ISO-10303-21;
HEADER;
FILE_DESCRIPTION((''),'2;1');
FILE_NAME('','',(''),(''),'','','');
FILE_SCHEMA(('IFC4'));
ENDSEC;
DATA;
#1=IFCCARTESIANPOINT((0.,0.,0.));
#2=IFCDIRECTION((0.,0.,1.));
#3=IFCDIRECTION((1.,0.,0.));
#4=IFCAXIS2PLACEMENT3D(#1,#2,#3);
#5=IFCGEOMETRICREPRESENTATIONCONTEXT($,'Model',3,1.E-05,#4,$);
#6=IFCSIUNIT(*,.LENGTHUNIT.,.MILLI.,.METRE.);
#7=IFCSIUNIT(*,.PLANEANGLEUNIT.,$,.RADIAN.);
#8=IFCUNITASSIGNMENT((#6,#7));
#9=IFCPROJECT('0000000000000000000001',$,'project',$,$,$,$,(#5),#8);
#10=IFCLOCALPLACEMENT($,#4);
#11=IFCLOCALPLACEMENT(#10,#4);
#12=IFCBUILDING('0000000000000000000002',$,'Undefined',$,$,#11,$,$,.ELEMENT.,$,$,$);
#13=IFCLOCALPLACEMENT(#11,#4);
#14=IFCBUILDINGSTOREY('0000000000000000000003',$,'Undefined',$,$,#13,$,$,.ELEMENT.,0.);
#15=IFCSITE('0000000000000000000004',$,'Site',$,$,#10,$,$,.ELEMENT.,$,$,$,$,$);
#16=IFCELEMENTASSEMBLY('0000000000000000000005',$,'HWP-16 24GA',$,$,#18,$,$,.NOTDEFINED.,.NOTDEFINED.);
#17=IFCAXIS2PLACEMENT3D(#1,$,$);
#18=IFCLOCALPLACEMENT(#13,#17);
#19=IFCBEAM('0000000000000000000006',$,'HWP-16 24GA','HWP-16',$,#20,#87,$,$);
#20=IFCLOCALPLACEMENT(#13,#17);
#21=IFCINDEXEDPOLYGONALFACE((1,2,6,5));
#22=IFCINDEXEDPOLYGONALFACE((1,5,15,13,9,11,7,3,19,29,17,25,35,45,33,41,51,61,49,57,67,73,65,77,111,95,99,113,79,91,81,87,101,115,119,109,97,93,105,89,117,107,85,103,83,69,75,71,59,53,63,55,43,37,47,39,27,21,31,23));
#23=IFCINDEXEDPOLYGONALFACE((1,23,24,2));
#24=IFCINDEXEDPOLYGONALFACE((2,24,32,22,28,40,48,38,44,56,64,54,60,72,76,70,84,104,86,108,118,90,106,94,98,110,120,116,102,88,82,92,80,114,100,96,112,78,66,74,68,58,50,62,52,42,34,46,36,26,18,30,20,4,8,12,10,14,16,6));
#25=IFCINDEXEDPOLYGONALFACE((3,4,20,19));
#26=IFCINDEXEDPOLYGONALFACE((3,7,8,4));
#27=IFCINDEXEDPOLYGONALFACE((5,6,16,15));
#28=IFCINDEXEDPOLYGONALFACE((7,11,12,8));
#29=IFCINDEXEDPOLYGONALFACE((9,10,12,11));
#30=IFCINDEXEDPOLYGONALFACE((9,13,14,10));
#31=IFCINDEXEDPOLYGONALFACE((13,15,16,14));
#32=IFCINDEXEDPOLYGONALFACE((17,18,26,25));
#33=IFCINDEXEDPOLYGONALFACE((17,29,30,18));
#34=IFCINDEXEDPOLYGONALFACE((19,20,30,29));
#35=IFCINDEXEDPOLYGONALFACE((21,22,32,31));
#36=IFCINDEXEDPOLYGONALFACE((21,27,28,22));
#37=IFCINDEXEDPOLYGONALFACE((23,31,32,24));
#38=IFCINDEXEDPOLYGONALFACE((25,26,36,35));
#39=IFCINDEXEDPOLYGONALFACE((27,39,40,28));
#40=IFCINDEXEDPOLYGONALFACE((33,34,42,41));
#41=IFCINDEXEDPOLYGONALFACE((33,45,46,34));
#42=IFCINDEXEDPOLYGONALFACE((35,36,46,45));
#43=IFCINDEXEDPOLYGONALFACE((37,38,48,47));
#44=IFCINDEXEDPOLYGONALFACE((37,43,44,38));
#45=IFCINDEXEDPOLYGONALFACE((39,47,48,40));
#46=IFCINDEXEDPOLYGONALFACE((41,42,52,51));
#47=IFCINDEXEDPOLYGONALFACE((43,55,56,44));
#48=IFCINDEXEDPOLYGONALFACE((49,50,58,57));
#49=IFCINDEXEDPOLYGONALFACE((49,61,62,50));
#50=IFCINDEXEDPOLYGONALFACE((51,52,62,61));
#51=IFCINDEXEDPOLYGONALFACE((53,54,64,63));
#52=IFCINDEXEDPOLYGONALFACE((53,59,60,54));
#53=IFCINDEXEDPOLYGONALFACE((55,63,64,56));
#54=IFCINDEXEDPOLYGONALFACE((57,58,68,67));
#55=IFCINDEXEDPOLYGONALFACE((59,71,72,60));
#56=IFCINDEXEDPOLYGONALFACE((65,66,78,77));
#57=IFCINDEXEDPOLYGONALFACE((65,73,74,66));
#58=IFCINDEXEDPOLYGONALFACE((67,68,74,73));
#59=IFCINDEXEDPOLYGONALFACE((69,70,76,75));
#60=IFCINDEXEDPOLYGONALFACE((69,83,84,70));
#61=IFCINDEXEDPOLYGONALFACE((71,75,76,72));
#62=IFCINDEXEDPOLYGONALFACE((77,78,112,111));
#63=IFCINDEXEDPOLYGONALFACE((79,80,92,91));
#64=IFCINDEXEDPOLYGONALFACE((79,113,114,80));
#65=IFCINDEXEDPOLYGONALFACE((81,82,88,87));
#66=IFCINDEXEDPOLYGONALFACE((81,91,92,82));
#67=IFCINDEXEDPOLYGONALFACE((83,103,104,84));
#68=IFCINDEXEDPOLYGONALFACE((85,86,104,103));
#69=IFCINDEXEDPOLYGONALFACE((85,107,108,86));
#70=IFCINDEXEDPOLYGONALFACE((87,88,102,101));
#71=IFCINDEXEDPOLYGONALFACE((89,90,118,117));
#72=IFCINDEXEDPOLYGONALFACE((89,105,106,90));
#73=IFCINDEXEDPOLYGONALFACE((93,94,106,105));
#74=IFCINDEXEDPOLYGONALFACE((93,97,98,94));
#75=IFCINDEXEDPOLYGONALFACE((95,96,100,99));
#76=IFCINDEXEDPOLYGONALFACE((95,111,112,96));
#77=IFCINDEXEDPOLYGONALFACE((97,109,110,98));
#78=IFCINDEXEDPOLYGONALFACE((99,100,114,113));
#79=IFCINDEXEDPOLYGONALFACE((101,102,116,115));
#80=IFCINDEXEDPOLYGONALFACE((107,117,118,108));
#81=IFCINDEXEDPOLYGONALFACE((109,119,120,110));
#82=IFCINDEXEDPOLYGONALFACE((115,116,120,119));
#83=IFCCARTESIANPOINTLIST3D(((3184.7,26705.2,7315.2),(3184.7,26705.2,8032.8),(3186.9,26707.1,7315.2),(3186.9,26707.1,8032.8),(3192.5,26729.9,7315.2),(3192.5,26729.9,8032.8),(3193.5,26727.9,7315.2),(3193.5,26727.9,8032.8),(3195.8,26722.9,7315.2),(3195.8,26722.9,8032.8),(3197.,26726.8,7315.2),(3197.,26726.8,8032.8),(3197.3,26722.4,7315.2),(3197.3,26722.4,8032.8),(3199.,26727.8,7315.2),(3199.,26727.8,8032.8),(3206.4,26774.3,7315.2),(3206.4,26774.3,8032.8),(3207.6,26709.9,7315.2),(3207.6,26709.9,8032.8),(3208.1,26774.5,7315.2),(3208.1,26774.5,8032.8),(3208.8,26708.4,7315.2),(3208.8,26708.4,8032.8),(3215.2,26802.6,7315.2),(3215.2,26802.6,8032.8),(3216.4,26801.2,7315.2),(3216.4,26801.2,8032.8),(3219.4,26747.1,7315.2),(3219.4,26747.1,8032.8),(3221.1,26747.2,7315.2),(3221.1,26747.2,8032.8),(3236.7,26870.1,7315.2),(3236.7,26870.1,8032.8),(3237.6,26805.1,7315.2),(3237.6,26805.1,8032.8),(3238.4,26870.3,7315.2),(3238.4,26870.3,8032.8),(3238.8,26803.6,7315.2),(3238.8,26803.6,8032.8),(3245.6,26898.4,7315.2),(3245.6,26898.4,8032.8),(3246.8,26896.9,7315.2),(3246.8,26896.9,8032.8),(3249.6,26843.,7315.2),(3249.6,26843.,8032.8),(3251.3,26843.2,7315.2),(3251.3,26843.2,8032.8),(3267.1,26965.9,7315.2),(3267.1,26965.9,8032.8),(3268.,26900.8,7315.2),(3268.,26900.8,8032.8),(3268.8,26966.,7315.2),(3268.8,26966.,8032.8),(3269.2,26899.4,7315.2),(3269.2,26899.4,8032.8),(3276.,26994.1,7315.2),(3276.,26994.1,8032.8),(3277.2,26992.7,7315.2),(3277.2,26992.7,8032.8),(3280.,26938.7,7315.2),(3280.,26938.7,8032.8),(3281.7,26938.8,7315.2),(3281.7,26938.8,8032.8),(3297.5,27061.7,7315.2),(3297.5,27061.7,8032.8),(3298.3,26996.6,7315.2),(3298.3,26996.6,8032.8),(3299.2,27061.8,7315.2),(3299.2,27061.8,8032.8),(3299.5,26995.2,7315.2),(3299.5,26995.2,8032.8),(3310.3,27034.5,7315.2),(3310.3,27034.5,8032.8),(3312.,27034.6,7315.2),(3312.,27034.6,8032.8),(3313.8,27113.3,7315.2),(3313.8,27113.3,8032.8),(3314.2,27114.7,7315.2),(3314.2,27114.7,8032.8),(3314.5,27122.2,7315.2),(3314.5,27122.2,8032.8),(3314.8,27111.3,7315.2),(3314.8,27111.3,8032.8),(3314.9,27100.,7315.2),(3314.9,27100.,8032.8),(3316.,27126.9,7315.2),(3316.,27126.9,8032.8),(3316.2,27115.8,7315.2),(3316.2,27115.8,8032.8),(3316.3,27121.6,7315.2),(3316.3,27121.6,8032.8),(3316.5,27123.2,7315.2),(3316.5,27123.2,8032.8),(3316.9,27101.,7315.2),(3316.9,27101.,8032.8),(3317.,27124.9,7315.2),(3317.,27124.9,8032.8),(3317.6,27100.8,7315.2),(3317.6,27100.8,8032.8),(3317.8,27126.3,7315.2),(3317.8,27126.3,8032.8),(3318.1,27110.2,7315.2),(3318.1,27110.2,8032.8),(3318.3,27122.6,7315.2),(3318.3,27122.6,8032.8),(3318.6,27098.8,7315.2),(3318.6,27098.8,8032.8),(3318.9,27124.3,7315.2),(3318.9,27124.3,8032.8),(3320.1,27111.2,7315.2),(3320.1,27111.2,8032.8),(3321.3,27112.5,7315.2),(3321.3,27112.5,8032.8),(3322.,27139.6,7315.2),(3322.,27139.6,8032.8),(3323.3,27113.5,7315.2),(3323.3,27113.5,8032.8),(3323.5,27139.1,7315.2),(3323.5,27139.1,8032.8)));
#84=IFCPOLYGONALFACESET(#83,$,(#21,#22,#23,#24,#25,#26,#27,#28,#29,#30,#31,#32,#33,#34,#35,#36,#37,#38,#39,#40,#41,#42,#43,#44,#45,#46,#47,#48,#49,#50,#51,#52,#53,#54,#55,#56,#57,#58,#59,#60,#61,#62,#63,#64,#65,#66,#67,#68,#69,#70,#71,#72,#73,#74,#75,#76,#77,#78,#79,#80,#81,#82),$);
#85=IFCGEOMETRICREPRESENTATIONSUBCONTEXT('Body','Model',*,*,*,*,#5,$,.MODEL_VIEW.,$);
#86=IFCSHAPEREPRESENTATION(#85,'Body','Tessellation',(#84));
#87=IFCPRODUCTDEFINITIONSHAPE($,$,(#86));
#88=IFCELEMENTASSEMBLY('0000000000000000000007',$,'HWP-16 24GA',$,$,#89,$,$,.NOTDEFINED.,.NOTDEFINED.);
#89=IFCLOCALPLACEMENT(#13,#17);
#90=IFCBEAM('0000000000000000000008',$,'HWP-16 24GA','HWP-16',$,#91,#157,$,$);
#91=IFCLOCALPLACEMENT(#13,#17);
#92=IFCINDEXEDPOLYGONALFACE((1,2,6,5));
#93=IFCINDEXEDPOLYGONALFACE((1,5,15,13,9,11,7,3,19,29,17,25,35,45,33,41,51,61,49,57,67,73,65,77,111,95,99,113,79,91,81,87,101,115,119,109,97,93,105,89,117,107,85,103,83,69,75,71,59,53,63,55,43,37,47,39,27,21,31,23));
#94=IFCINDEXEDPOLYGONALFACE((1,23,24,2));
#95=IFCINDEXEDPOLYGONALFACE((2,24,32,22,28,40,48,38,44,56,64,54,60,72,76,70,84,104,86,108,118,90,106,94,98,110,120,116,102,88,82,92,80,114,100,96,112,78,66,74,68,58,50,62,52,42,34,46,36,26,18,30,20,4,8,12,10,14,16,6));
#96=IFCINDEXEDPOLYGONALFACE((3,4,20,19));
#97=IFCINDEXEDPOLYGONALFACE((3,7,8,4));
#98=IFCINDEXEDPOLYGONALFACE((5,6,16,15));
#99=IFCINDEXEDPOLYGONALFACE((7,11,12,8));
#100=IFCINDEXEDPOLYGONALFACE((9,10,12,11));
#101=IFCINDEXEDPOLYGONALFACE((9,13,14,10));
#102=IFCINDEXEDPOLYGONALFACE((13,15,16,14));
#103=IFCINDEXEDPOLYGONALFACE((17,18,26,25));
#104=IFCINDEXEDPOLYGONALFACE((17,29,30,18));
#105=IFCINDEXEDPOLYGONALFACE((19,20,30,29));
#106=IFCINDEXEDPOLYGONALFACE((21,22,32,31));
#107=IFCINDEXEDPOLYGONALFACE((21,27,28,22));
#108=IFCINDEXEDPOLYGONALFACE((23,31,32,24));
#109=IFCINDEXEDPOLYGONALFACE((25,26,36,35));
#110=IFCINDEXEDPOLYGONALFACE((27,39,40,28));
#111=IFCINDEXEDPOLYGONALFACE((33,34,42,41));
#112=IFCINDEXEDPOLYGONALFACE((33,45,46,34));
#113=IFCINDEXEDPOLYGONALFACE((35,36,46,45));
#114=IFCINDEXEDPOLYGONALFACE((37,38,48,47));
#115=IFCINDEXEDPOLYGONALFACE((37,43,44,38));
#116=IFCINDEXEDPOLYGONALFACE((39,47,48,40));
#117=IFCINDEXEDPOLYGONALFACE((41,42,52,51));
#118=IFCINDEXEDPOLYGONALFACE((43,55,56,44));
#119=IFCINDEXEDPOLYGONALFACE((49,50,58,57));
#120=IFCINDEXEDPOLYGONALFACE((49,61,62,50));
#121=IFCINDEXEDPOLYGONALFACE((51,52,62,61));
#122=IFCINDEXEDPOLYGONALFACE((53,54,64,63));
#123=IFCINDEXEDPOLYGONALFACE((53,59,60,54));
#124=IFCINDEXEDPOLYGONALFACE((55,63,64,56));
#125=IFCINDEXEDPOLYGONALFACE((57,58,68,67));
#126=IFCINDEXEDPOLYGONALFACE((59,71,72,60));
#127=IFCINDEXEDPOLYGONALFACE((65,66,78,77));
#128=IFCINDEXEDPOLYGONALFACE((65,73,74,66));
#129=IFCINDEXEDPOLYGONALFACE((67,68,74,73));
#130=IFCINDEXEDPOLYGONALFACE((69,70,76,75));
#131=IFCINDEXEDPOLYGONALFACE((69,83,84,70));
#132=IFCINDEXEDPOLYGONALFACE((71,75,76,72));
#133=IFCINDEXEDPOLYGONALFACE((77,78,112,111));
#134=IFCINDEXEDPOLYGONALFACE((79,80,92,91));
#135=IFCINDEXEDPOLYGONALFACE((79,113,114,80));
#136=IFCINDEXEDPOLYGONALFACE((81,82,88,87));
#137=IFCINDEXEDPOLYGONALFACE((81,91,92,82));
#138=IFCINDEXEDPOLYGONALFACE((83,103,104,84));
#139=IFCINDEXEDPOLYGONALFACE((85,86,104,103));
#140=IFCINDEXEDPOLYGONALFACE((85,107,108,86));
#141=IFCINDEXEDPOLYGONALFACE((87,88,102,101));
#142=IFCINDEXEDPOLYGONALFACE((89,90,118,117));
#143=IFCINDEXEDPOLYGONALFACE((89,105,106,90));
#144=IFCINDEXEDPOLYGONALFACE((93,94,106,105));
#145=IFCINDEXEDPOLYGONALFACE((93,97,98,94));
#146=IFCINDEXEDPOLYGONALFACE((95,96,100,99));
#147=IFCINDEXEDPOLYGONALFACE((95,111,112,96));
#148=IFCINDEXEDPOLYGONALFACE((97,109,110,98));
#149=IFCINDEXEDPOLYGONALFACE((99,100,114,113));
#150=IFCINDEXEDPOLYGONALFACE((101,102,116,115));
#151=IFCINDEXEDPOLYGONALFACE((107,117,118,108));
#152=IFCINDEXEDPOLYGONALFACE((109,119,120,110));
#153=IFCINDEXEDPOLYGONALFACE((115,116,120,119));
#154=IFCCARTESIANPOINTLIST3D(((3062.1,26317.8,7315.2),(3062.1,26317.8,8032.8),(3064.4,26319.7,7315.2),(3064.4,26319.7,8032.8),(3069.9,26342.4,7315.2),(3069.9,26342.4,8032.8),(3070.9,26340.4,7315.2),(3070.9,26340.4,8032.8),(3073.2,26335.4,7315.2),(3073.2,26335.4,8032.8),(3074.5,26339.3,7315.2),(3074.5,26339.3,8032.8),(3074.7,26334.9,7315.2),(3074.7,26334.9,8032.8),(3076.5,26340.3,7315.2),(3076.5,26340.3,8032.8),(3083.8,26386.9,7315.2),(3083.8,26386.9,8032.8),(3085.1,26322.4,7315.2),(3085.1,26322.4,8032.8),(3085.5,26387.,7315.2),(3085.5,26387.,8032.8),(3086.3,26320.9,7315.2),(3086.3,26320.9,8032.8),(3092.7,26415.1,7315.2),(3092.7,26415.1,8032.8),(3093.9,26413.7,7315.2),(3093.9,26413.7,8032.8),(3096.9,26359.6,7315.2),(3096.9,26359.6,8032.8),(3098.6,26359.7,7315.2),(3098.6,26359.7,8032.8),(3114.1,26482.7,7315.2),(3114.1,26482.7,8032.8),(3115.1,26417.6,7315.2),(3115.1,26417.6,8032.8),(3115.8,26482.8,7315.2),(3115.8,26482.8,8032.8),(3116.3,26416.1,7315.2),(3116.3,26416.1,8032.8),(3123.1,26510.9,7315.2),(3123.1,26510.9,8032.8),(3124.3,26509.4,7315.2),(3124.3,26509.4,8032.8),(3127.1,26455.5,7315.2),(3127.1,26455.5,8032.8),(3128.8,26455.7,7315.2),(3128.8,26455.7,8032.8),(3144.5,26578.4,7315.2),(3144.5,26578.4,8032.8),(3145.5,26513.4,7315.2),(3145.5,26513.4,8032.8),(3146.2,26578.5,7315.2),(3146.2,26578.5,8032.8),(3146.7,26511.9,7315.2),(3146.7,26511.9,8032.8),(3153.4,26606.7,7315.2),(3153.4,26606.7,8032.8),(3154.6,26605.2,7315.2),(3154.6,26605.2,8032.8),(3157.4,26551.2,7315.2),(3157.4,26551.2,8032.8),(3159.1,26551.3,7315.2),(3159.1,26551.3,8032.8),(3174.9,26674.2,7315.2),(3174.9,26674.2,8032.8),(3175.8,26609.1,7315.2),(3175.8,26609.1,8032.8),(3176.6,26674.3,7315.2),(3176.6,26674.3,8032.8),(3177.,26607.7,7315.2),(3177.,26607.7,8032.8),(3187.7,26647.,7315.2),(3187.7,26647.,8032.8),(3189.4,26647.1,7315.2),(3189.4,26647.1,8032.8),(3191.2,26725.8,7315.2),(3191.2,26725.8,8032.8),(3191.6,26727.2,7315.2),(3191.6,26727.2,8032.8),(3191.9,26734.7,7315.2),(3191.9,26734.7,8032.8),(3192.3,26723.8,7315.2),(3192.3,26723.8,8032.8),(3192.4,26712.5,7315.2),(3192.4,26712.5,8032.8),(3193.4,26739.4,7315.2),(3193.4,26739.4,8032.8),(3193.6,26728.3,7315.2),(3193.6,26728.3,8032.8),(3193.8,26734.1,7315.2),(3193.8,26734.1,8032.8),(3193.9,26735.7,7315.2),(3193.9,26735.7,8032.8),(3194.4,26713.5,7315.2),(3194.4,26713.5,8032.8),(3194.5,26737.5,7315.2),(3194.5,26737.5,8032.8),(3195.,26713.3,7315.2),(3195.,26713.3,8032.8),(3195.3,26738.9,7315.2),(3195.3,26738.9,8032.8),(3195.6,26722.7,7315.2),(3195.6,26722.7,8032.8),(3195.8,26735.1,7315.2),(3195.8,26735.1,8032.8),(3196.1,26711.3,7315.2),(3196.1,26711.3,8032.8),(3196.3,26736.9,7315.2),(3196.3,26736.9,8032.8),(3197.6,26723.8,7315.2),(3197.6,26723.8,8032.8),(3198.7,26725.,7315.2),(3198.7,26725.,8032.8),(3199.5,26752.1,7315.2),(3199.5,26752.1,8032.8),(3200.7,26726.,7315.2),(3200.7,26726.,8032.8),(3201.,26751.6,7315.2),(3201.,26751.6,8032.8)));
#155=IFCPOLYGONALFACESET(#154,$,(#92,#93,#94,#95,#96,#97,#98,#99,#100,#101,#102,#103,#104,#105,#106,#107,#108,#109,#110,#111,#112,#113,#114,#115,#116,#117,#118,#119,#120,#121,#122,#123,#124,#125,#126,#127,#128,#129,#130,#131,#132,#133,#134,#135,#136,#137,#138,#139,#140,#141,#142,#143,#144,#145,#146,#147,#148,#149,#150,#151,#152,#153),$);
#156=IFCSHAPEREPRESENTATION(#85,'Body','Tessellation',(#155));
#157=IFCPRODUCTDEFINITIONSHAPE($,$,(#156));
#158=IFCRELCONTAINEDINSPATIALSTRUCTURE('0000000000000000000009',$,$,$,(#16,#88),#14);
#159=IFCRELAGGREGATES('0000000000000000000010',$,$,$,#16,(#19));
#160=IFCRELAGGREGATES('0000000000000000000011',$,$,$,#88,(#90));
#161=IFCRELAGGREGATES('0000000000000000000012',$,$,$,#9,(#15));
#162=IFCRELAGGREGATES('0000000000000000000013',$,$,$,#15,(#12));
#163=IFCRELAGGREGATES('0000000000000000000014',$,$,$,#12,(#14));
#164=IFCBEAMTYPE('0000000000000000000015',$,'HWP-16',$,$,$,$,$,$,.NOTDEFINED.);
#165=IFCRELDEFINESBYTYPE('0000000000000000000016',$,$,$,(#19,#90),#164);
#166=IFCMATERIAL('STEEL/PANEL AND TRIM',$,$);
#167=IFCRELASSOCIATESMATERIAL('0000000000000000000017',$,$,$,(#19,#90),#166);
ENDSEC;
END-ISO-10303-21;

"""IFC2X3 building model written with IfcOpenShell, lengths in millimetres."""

from ifc_helpers import new_model, si_unit, frame, origin_with_axes, place, context, subcontext, project, spatial, polyline, outline, extrude, clip, halfspace, material, type_object, element, aggregate, save


model = new_model("IFC2X3")

# Units and contexts
model_context = context("Model", 3, precision=1e-05, world=origin_with_axes())
body_context = subcontext(model_context, "Body", "Model", "MODEL_VIEW")
ifc_project = project(units=[si_unit("LENGTHUNIT", "METRE", prefix="MILLI"), si_unit("PLANEANGLEUNIT", "RADIAN")], contexts=[model_context])

# Site, building, storey
site_placement = place(None, origin_with_axes())
site = spatial("IfcSite", under=ifc_project, at=site_placement, Name="Site", CompositionType="ELEMENT")
building_placement = place(site_placement, origin_with_axes())
building = spatial("IfcBuilding", under=site, at=building_placement, Name="Undefined", CompositionType="ELEMENT")
storey_placement = place(building_placement, origin_with_axes())
storey = spatial("IfcBuildingStorey", under=building, at=storey_placement, Name="Undefined", CompositionType="ELEMENT", Elevation=0.0)

# Element assemblies, beams
ifc_material_1 = material(Name="STEEL/PANEL AND TRIM")
beam_type_1 = type_object("IfcBeamType", Name="HWP-16", PredefinedType="NOTDEFINED")
assembly_1_placement = place(storey_placement, origin_with_axes())
assembly_1 = element("IfcElementAssembly", 1, at=assembly_1_placement, inside=storey, Name="HWP-16 24GA", AssemblyPlace="NOTDEFINED", PredefinedType="NOTDEFINED")
beam_1_placement = place(assembly_1_placement, frame((3208.8, 26708.4, 8032.8), z_axis=(-0.953453, 0.301541, 0.0), x_axis=(0.0, 0.0, -1.0)))
beam_1 = element("IfcBeam", 2, at=beam_1_placement, type_object=beam_type_1, material=ifc_material_1, Name="HWP-16 24GA", Description="HWP-16", context=body_context, shape_type="Clipping", body=[
    clip(extrude(outline(polyline([(40.7, 0.0), (0.0, 0.0), (-10.3, 22.1), (15.5, 22.1), (15.5, 15.2), (9.9, 15.2), (9.9, 16.8), (13.9, 16.8), (13.9, 20.5), (-7.8, 20.5), (1.0, 1.6), (40.1, 1.6), (62.1, 22.2), (91.7, 22.3), (100.8, 1.7), (140.6, 1.7), (162.6, 22.2), (192.2, 22.2), (201.3, 1.6), (241.0, 1.6), (263.1, 22.1), (292.7, 22.1), (301.8, 1.6), (341.5, 1.6), (363.5, 22.0), (417.6, 22.0), (417.6, 15.3), (406.9, 15.3), (406.9, 14.6), (419.2, 14.6), (419.2, 22.1), (426.4, 22.1), (426.4, 24.0), (431.3, 24.0), (431.3, 22.1), (445.2, 22.1), (445.2, 20.5), (429.7, 20.5), (429.7, 22.5), (427.9, 22.5), (427.9, 20.5), (420.7, 20.5), (420.7, 13.0), (405.3, 13.0), (405.3, 16.9), (416.0, 16.9), (416.0, 20.4), (364.1, 20.4), (342.1, 0.0), (300.7, 0.0), (291.6, 20.5), (263.7, 20.5), (241.6, 0.0), (200.3, 0.0), (191.2, 20.6), (163.2, 20.6), (141.3, 0.1), (99.8, 0.1), (90.7, 20.7), (62.7, 20.6), (40.7, 0.0)])), frame((10000.0, 0.0, 0.0), z_axis=(-1.0, 0.0, 0.0), x_axis=(0.0, -1.0, 0.0)), (0.0, 0.0, 1.0), 10000.0), halfspace(frame((717.5, -500.0, -500.0), z_axis=(1.0, 0.0, 0.0), x_axis=(0.0, 0.0, 1.0)), False)),
])
aggregate(assembly_1, [beam_1])
assembly_2_placement = place(storey_placement, origin_with_axes())
assembly_2 = element("IfcElementAssembly", 3, at=assembly_2_placement, inside=storey, Name="HWP-16 24GA", AssemblyPlace="NOTDEFINED", PredefinedType="NOTDEFINED")
beam_2_placement = place(assembly_2_placement, frame((3086.3, 26320.9, 8032.8), z_axis=(-0.953453, 0.301541, 0.0), x_axis=(0.0, 0.0, -1.0)))
beam_2 = element("IfcBeam", 4, at=beam_2_placement, type_object=beam_type_1, material=ifc_material_1, Name="HWP-16 24GA", Description="HWP-16", context=body_context, shape_type="Clipping", body=[
    clip(extrude(outline(polyline([(40.7, 0.0), (0.0, 0.0), (-10.3, 22.1), (15.5, 22.1), (15.5, 15.2), (9.9, 15.2), (9.9, 16.8), (13.9, 16.8), (13.9, 20.5), (-7.8, 20.5), (1.0, 1.6), (40.1, 1.6), (62.1, 22.2), (91.7, 22.3), (100.8, 1.7), (140.6, 1.7), (162.6, 22.2), (192.2, 22.2), (201.3, 1.6), (241.0, 1.6), (263.1, 22.1), (292.7, 22.1), (301.8, 1.6), (341.5, 1.6), (363.5, 22.0), (417.6, 22.0), (417.6, 15.3), (406.9, 15.3), (406.9, 14.6), (419.2, 14.6), (419.2, 22.1), (426.4, 22.1), (426.4, 24.0), (431.3, 24.0), (431.3, 22.1), (445.2, 22.1), (445.2, 20.5), (429.7, 20.5), (429.7, 22.5), (427.9, 22.5), (427.9, 20.5), (420.7, 20.5), (420.7, 13.0), (405.3, 13.0), (405.3, 16.9), (416.0, 16.9), (416.0, 20.4), (364.1, 20.4), (342.1, 0.0), (300.7, 0.0), (291.6, 20.5), (263.7, 20.5), (241.6, 0.0), (200.3, 0.0), (191.2, 20.6), (163.2, 20.6), (141.3, 0.1), (99.8, 0.1), (90.7, 20.7), (62.7, 20.6), (40.7, 0.0)])), frame((10000.0, 0.0, 0.0), z_axis=(-1.0, 0.0, 0.0), x_axis=(0.0, -1.0, 0.0)), (0.0, 0.0, 1.0), 10000.0), halfspace(frame((717.5, -500.0, -500.0), z_axis=(1.0, 0.0, 0.0), x_axis=(0.0, 0.0, 1.0)), False)),
])
aggregate(assembly_2, [beam_2])

save(model, "model.ifc")
